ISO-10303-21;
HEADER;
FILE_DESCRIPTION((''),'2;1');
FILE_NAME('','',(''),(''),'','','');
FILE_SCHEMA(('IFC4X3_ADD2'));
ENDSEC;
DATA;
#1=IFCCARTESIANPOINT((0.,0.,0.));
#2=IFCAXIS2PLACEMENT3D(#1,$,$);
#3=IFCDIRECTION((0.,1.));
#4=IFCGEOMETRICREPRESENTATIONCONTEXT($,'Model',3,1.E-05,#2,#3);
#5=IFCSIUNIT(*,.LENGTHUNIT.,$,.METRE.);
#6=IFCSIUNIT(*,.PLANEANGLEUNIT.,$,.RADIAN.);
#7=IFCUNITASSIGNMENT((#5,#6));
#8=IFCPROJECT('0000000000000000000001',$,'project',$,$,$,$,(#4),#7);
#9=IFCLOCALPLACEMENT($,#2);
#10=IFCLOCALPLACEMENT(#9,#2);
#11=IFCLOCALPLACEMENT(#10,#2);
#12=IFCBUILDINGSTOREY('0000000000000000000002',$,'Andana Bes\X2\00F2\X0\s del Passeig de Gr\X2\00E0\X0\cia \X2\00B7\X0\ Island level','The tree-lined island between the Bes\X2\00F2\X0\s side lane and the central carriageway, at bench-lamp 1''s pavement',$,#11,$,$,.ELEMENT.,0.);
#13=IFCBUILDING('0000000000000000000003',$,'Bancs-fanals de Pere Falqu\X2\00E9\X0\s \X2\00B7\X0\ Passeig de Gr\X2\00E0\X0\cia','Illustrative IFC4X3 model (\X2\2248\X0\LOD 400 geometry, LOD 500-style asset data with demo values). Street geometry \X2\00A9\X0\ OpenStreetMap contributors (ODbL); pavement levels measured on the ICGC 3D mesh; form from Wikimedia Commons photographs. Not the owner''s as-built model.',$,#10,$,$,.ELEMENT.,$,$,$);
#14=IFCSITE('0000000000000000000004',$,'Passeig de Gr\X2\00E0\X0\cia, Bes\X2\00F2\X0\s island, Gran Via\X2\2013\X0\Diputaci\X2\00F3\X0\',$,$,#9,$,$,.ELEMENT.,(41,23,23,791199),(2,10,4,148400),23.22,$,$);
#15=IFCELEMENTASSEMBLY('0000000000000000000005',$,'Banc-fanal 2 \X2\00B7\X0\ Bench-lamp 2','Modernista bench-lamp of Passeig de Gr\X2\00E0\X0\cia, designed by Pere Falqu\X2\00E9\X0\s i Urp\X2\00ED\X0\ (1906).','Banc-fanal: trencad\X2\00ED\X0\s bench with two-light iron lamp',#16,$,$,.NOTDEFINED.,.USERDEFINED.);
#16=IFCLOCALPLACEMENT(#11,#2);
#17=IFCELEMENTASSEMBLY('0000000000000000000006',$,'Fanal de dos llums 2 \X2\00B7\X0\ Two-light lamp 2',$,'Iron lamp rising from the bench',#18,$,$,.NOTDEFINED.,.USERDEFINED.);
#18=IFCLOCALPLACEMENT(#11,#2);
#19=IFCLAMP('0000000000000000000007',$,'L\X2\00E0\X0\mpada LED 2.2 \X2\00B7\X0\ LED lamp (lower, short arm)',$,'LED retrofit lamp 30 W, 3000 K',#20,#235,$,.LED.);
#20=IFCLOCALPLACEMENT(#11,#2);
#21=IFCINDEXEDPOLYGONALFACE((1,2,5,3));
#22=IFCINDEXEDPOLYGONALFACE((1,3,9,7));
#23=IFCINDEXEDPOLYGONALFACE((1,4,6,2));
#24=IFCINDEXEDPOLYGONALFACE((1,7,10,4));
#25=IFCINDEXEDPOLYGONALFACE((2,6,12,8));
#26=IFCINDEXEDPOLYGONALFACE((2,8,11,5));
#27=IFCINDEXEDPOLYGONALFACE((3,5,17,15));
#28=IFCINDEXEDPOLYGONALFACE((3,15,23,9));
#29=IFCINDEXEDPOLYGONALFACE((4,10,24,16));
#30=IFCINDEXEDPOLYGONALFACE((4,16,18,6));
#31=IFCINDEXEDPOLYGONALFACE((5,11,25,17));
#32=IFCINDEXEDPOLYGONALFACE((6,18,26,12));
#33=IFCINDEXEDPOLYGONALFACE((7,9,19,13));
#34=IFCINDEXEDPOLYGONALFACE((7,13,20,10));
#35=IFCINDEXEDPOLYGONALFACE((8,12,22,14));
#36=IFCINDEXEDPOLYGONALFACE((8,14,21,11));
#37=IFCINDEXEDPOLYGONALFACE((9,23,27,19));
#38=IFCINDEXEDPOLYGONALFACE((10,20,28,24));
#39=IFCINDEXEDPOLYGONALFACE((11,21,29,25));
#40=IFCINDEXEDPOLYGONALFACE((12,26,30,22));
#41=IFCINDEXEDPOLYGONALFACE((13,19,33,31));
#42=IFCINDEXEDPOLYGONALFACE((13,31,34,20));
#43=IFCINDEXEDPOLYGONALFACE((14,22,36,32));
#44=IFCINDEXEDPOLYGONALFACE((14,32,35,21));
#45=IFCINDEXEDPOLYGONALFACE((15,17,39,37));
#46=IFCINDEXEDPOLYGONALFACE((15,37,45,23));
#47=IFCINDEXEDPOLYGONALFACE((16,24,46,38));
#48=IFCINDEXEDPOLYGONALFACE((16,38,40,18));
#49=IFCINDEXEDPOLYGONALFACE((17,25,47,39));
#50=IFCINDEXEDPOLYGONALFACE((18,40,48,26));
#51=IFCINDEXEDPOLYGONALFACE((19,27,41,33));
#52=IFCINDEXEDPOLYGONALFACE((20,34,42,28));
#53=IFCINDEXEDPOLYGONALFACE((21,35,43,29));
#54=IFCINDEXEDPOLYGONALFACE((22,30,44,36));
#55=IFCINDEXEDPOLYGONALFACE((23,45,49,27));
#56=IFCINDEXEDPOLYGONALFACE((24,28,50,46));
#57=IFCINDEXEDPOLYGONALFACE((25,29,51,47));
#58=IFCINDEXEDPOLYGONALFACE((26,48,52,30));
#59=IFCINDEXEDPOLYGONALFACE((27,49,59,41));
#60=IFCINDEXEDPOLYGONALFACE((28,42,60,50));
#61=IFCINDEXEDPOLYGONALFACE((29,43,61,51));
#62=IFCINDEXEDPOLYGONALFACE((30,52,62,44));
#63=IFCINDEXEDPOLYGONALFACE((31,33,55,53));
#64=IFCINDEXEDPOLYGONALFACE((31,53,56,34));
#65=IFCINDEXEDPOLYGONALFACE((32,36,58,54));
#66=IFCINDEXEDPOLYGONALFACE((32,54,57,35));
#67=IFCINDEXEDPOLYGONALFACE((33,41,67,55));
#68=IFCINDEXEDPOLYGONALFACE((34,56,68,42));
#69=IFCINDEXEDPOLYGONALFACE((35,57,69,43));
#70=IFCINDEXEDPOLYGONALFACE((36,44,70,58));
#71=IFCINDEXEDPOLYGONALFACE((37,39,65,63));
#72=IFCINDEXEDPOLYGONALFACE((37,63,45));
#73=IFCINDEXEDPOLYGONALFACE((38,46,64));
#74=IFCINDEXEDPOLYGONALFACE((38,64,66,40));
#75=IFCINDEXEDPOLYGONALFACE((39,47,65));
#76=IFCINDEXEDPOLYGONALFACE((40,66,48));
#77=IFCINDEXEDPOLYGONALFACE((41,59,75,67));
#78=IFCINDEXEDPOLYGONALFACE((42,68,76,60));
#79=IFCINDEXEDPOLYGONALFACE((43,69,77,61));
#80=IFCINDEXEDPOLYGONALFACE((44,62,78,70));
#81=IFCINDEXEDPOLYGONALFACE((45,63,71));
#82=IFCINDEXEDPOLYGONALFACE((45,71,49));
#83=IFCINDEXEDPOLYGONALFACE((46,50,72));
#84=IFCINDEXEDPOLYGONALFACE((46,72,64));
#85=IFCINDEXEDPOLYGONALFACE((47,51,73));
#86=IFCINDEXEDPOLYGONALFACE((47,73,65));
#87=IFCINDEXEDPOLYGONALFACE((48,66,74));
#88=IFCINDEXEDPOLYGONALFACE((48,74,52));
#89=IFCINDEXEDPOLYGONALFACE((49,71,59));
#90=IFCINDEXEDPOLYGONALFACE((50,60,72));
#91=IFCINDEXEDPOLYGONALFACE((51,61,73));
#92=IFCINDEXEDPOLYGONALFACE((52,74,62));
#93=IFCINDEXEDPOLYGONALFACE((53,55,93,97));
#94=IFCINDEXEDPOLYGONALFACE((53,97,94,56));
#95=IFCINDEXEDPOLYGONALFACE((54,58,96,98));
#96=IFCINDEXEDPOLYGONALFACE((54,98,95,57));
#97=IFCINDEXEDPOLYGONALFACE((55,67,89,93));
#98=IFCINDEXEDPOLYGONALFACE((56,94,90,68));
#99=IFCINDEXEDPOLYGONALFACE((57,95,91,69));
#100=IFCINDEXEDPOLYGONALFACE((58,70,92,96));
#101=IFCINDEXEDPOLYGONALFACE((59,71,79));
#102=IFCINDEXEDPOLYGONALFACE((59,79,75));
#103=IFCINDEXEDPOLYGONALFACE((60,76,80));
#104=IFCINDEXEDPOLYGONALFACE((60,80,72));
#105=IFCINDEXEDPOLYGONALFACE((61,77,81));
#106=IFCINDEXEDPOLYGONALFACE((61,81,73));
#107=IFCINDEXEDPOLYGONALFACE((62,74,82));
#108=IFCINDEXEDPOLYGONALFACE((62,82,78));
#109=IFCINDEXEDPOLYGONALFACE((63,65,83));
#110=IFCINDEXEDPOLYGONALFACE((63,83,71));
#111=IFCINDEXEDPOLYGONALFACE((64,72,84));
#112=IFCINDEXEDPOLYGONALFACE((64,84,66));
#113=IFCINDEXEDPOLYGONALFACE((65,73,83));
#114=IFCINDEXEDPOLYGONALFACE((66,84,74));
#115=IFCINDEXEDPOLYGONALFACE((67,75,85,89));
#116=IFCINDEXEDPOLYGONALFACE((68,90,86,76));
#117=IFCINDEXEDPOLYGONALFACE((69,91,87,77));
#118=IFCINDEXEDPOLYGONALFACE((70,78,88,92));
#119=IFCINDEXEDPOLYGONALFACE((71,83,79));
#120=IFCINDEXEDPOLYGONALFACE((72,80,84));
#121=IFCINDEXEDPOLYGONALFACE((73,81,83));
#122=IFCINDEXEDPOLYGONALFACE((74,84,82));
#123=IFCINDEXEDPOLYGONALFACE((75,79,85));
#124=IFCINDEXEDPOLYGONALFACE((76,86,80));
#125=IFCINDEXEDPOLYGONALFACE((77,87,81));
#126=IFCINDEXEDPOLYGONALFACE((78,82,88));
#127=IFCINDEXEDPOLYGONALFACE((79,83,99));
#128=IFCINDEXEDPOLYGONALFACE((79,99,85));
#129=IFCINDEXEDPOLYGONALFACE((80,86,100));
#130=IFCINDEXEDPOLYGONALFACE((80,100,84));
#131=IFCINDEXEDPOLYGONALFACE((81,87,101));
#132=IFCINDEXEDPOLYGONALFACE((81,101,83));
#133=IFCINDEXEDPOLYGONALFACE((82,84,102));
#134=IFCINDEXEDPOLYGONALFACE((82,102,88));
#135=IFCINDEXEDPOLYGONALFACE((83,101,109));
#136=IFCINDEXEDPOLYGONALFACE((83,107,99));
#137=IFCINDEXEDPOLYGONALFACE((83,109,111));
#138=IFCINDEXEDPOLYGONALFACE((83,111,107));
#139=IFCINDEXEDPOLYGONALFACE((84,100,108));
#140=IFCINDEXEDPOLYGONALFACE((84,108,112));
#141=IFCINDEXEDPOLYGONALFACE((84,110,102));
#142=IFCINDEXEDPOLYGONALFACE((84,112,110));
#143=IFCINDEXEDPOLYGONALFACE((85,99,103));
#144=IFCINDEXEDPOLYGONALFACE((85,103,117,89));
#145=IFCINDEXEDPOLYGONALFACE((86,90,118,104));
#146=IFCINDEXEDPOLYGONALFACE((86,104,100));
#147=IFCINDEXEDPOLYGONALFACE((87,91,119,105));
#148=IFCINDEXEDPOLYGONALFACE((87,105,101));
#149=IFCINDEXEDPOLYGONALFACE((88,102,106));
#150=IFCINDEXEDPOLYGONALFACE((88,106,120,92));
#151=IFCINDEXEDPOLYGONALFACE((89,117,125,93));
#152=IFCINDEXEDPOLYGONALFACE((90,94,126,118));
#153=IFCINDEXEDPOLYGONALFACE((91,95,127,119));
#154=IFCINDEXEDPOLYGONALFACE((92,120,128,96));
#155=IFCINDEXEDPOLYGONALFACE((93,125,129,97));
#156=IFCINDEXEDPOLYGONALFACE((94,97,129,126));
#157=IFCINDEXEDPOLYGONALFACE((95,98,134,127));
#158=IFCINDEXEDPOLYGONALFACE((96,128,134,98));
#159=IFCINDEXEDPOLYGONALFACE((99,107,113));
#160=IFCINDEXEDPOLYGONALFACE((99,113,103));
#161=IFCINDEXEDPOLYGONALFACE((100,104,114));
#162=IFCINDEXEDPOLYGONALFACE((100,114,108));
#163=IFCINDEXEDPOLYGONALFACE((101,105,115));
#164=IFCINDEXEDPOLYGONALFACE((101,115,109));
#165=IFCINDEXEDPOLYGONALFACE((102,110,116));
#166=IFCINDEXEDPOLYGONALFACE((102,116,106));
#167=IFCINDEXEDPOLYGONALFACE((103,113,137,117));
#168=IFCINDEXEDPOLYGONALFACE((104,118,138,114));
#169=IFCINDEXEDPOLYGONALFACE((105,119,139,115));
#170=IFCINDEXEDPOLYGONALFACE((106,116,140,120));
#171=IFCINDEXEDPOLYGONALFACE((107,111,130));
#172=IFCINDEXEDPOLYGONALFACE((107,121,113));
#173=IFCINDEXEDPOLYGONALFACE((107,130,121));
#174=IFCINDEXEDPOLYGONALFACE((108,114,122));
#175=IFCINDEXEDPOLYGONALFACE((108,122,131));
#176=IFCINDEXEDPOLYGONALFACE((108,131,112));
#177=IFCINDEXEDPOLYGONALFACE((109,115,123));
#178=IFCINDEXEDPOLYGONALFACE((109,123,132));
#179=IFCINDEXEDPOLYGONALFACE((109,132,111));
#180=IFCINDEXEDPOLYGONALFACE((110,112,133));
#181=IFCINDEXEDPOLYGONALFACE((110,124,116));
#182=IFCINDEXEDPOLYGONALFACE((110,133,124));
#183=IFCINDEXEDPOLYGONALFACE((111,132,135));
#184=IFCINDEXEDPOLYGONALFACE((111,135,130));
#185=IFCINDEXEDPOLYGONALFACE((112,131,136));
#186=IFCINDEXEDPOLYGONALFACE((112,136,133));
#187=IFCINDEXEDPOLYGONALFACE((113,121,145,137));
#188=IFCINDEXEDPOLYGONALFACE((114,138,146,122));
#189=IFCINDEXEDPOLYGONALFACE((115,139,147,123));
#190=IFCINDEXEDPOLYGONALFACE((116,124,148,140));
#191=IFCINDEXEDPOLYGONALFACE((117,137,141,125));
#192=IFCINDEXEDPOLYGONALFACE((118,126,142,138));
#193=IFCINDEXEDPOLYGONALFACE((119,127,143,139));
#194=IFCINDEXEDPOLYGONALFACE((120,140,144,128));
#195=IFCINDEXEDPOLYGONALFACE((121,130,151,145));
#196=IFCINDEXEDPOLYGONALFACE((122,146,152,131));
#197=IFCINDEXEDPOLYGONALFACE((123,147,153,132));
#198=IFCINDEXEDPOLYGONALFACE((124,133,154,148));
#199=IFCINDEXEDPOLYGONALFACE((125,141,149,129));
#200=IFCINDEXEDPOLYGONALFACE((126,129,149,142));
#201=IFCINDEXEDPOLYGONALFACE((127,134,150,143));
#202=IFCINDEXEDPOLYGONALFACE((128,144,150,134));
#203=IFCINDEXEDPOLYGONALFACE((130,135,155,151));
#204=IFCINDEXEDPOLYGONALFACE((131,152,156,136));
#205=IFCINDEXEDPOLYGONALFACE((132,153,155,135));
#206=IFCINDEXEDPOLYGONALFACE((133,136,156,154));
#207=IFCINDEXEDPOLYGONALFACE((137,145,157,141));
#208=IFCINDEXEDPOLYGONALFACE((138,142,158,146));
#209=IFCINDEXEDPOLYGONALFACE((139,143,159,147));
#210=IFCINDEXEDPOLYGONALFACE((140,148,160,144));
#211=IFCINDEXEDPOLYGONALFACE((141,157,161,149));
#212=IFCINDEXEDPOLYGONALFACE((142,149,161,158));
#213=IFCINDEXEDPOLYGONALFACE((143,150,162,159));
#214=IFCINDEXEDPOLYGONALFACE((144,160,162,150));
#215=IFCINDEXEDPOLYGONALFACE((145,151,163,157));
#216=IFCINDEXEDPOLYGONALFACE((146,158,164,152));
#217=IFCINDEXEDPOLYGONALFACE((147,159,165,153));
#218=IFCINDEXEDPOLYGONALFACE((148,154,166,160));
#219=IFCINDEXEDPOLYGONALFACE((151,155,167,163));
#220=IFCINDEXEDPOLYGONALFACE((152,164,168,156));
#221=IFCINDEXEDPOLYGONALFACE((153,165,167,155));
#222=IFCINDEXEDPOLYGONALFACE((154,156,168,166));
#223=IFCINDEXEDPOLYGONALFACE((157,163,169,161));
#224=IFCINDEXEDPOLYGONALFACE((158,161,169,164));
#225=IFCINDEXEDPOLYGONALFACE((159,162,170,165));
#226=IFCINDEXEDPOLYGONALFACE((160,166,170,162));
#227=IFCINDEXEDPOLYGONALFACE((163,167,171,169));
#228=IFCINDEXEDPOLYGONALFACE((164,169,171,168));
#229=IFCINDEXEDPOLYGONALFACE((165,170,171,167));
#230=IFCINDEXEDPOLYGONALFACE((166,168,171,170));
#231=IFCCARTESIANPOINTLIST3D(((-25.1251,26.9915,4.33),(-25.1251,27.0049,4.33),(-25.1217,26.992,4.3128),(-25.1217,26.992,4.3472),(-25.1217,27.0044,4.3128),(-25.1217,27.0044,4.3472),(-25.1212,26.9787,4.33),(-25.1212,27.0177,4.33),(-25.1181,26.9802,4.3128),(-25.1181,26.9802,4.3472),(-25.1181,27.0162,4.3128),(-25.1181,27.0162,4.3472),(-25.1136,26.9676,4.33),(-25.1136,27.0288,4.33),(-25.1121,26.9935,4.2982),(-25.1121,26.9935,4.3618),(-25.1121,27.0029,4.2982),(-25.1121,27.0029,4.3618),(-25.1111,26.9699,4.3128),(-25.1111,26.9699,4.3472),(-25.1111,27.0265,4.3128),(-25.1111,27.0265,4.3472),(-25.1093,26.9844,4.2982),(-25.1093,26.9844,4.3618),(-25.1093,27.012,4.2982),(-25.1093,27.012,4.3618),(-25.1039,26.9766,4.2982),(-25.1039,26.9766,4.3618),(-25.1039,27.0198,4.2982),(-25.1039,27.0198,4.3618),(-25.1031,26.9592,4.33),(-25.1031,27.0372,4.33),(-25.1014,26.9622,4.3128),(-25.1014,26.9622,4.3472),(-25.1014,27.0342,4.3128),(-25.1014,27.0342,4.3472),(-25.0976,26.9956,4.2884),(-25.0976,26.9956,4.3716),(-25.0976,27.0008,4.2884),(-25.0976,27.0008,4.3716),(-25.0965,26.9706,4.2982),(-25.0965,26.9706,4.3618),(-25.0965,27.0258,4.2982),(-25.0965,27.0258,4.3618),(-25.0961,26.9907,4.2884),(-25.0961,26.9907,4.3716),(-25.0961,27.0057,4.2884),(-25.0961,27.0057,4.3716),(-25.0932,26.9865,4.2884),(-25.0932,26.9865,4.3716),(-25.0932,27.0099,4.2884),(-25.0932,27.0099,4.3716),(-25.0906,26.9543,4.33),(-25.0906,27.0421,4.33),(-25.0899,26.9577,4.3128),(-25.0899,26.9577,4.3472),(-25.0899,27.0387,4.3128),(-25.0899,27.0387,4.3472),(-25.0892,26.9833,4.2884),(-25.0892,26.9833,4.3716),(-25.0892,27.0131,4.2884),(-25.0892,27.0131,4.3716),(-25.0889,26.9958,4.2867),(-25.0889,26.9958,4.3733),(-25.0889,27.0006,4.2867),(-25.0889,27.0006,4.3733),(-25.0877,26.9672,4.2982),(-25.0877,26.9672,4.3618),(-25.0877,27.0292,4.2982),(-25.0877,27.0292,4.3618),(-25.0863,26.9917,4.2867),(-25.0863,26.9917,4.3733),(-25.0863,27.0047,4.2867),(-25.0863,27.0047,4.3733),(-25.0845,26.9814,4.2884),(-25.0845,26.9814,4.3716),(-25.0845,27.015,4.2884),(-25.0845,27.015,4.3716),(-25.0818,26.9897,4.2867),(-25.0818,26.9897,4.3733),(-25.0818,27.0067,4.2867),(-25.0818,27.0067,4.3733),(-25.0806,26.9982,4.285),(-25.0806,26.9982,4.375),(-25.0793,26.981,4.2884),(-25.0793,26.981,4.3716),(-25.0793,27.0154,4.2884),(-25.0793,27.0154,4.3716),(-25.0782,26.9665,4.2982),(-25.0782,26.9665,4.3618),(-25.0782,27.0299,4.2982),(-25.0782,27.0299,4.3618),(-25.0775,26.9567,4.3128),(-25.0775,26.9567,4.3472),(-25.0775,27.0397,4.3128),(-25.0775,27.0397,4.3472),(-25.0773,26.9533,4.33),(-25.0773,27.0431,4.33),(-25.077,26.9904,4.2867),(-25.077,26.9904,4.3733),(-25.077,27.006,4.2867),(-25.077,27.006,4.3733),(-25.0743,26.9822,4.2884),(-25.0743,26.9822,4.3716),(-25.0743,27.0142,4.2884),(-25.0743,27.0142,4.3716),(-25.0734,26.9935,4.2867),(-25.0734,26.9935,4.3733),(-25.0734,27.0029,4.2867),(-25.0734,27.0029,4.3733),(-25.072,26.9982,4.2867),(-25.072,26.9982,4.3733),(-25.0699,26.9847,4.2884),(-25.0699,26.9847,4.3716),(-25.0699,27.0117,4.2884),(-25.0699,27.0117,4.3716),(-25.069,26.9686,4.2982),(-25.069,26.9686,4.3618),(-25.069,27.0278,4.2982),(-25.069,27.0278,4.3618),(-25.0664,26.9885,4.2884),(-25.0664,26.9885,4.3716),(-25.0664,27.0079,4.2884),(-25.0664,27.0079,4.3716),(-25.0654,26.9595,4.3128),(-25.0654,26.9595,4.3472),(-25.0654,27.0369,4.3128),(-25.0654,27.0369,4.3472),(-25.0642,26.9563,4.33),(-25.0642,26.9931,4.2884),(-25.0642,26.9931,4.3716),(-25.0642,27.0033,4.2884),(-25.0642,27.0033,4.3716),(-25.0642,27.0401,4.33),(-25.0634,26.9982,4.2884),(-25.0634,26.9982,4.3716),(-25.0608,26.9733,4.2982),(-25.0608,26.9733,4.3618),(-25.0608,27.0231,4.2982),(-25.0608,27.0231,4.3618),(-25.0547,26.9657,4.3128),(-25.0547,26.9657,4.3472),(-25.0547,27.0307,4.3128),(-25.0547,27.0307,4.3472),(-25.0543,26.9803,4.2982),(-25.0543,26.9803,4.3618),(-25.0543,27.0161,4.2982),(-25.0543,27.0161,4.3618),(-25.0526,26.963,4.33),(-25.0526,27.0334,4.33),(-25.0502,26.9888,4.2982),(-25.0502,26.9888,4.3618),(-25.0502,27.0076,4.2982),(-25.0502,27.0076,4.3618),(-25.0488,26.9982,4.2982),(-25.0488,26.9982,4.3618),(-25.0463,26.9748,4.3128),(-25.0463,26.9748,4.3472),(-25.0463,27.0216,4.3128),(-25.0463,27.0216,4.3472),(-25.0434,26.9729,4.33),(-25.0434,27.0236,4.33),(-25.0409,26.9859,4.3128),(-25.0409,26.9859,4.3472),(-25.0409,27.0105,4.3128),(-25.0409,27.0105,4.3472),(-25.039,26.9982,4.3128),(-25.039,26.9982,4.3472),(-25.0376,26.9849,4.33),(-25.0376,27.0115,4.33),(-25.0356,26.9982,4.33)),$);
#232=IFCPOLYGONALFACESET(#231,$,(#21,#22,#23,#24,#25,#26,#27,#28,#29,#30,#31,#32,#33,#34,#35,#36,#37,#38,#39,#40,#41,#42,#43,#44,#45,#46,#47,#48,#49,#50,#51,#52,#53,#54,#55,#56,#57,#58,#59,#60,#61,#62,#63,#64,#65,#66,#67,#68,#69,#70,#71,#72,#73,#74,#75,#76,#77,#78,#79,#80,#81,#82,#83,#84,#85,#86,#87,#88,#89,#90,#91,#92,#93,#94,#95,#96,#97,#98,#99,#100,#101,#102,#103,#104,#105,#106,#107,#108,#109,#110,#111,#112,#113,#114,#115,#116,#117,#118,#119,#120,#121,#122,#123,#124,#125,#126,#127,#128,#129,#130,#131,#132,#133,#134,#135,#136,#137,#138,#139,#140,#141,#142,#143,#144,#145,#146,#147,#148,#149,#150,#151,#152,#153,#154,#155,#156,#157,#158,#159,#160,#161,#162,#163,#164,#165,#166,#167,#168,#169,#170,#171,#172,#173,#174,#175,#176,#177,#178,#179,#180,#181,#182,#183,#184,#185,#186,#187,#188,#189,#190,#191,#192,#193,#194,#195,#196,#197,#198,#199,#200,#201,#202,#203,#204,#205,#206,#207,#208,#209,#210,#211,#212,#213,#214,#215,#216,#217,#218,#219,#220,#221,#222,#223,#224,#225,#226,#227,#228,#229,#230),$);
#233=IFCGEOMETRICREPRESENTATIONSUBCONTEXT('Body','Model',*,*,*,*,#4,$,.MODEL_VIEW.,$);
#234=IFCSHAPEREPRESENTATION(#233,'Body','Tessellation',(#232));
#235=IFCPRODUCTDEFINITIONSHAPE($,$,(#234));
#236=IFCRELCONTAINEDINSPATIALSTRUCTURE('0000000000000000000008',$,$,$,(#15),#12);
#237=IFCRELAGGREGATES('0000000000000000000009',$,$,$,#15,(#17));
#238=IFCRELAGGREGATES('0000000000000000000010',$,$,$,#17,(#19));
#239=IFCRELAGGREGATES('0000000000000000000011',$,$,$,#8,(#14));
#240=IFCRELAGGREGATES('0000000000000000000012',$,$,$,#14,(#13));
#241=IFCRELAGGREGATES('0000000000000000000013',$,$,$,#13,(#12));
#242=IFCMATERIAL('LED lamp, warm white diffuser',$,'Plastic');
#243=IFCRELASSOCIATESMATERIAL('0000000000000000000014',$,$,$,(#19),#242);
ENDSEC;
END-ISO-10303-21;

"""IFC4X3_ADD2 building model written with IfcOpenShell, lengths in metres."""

from ifc_helpers import new_model, entity, si_unit, direction, origin, place, context, subcontext, project, spatial, material, element, aggregate, save


model = new_model("IFC4X3_ADD2")

# Units and contexts
model_context = context("Model", 3, precision=1e-05, world=origin(), true_north=direction((0.0, 1.0)))
body_context = subcontext(model_context, "Body", "Model", "MODEL_VIEW")
ifc_project = project(units=[si_unit("LENGTHUNIT", "METRE"), si_unit("PLANEANGLEUNIT", "RADIAN")], contexts=[model_context])

# Site, building, storey
site_placement = place(None, origin())
site = spatial("IfcSite", under=ifc_project, at=site_placement, Name="Passeig de Gràcia, Besòs island, Gran Via–Diputació", CompositionType="ELEMENT", RefLatitude=(41, 23, 23, 791199), RefLongitude=(2, 10, 4, 148400), RefElevation=23.22)
building_placement = place(site_placement, origin())
building = spatial("IfcBuilding", under=site, at=building_placement, Name="Bancs-fanals de Pere Falqués · Passeig de Gràcia", Description="Illustrative IFC4X3 model (≈LOD 400 geometry, LOD 500-style asset data with demo values). Street geometry © OpenStreetMap contributors (ODbL); pavement levels measured on the ICGC 3D mesh; form from Wikimedia Commons photographs. Not the owner's as-built model.", CompositionType="ELEMENT")
storey_placement = place(building_placement, origin())
storey = spatial("IfcBuildingStorey", under=building, at=storey_placement, Name="Andana Besòs del Passeig de Gràcia · Island level", Description="The tree-lined island between the Besòs side lane and the central carriageway, at bench-lamp 1's pavement", CompositionType="ELEMENT", Elevation=0.0)

# Element assemblies
assembly_1_placement = place(building_placement, origin())
assembly_1 = element("IfcElementAssembly", 1, at=assembly_1_placement, inside=storey, Name="Banc-fanal 2 · Bench-lamp 2", Description="Modernista bench-lamp of Passeig de Gràcia, designed by Pere Falqués i Urpí (1906).", ObjectType="Banc-fanal: trencadís bench with two-light iron lamp", AssemblyPlace="NOTDEFINED", PredefinedType="USERDEFINED")
assembly_2_placement = place(building_placement, origin())
assembly_2 = element("IfcElementAssembly", 2, at=assembly_2_placement, Name="Fanal de dos llums 2 · Two-light lamp 2", ObjectType="Iron lamp rising from the bench", AssemblyPlace="NOTDEFINED", PredefinedType="USERDEFINED")
aggregate(assembly_1, [assembly_2])

# Shared definitions
ifc_material_1 = material(Name="LED lamp, warm white diffuser", Category="Plastic")

# Lamp
lamp_1_placement = place(building_placement, origin())
lamp_1 = element("IfcLamp", 3, at=lamp_1_placement, material=ifc_material_1, Name="Làmpada LED 2.2 · LED lamp (lower, short arm)", ObjectType="LED retrofit lamp 30 W, 3000 K", PredefinedType="LED", context=body_context, shape_type="SweptSolid", body=[
    entity("IfcRevolvedAreaSolid", entity("IfcArbitraryClosedProfileDef", "AREA", None, entity("IfcPolyline", [entity("IfcCartesianPoint", [0.0, -0.045]), entity("IfcCartesianPoint", [0.0172, -0.0416]), entity("IfcCartesianPoint", [0.0318, -0.0318]), entity("IfcCartesianPoint", [0.0416, -0.0172]), entity("IfcCartesianPoint", [0.045, 0.0]), entity("IfcCartesianPoint", [0.0416, 0.0172]), entity("IfcCartesianPoint", [0.0318, 0.0318]), entity("IfcCartesianPoint", [0.0172, 0.0416]), entity("IfcCartesianPoint", [0.0, 0.045]), entity("IfcCartesianPoint", [0.0, -0.045])])), entity("IfcAxis2Placement3D", entity("IfcCartesianPoint", [-25.0806, 26.9982, 4.33]), entity("IfcDirection", [0.0, -1.0, 0.0]), entity("IfcDirection", [1.0, 0.0, 0.0])), entity("IfcAxis1Placement", entity("IfcCartesianPoint", [0.0, 0.0, 0.0]), entity("IfcDirection", [0.0, 1.0, 0.0])), 6.283185),
])
aggregate(assembly_2, [lamp_1])

save(model, "model.ifc")
